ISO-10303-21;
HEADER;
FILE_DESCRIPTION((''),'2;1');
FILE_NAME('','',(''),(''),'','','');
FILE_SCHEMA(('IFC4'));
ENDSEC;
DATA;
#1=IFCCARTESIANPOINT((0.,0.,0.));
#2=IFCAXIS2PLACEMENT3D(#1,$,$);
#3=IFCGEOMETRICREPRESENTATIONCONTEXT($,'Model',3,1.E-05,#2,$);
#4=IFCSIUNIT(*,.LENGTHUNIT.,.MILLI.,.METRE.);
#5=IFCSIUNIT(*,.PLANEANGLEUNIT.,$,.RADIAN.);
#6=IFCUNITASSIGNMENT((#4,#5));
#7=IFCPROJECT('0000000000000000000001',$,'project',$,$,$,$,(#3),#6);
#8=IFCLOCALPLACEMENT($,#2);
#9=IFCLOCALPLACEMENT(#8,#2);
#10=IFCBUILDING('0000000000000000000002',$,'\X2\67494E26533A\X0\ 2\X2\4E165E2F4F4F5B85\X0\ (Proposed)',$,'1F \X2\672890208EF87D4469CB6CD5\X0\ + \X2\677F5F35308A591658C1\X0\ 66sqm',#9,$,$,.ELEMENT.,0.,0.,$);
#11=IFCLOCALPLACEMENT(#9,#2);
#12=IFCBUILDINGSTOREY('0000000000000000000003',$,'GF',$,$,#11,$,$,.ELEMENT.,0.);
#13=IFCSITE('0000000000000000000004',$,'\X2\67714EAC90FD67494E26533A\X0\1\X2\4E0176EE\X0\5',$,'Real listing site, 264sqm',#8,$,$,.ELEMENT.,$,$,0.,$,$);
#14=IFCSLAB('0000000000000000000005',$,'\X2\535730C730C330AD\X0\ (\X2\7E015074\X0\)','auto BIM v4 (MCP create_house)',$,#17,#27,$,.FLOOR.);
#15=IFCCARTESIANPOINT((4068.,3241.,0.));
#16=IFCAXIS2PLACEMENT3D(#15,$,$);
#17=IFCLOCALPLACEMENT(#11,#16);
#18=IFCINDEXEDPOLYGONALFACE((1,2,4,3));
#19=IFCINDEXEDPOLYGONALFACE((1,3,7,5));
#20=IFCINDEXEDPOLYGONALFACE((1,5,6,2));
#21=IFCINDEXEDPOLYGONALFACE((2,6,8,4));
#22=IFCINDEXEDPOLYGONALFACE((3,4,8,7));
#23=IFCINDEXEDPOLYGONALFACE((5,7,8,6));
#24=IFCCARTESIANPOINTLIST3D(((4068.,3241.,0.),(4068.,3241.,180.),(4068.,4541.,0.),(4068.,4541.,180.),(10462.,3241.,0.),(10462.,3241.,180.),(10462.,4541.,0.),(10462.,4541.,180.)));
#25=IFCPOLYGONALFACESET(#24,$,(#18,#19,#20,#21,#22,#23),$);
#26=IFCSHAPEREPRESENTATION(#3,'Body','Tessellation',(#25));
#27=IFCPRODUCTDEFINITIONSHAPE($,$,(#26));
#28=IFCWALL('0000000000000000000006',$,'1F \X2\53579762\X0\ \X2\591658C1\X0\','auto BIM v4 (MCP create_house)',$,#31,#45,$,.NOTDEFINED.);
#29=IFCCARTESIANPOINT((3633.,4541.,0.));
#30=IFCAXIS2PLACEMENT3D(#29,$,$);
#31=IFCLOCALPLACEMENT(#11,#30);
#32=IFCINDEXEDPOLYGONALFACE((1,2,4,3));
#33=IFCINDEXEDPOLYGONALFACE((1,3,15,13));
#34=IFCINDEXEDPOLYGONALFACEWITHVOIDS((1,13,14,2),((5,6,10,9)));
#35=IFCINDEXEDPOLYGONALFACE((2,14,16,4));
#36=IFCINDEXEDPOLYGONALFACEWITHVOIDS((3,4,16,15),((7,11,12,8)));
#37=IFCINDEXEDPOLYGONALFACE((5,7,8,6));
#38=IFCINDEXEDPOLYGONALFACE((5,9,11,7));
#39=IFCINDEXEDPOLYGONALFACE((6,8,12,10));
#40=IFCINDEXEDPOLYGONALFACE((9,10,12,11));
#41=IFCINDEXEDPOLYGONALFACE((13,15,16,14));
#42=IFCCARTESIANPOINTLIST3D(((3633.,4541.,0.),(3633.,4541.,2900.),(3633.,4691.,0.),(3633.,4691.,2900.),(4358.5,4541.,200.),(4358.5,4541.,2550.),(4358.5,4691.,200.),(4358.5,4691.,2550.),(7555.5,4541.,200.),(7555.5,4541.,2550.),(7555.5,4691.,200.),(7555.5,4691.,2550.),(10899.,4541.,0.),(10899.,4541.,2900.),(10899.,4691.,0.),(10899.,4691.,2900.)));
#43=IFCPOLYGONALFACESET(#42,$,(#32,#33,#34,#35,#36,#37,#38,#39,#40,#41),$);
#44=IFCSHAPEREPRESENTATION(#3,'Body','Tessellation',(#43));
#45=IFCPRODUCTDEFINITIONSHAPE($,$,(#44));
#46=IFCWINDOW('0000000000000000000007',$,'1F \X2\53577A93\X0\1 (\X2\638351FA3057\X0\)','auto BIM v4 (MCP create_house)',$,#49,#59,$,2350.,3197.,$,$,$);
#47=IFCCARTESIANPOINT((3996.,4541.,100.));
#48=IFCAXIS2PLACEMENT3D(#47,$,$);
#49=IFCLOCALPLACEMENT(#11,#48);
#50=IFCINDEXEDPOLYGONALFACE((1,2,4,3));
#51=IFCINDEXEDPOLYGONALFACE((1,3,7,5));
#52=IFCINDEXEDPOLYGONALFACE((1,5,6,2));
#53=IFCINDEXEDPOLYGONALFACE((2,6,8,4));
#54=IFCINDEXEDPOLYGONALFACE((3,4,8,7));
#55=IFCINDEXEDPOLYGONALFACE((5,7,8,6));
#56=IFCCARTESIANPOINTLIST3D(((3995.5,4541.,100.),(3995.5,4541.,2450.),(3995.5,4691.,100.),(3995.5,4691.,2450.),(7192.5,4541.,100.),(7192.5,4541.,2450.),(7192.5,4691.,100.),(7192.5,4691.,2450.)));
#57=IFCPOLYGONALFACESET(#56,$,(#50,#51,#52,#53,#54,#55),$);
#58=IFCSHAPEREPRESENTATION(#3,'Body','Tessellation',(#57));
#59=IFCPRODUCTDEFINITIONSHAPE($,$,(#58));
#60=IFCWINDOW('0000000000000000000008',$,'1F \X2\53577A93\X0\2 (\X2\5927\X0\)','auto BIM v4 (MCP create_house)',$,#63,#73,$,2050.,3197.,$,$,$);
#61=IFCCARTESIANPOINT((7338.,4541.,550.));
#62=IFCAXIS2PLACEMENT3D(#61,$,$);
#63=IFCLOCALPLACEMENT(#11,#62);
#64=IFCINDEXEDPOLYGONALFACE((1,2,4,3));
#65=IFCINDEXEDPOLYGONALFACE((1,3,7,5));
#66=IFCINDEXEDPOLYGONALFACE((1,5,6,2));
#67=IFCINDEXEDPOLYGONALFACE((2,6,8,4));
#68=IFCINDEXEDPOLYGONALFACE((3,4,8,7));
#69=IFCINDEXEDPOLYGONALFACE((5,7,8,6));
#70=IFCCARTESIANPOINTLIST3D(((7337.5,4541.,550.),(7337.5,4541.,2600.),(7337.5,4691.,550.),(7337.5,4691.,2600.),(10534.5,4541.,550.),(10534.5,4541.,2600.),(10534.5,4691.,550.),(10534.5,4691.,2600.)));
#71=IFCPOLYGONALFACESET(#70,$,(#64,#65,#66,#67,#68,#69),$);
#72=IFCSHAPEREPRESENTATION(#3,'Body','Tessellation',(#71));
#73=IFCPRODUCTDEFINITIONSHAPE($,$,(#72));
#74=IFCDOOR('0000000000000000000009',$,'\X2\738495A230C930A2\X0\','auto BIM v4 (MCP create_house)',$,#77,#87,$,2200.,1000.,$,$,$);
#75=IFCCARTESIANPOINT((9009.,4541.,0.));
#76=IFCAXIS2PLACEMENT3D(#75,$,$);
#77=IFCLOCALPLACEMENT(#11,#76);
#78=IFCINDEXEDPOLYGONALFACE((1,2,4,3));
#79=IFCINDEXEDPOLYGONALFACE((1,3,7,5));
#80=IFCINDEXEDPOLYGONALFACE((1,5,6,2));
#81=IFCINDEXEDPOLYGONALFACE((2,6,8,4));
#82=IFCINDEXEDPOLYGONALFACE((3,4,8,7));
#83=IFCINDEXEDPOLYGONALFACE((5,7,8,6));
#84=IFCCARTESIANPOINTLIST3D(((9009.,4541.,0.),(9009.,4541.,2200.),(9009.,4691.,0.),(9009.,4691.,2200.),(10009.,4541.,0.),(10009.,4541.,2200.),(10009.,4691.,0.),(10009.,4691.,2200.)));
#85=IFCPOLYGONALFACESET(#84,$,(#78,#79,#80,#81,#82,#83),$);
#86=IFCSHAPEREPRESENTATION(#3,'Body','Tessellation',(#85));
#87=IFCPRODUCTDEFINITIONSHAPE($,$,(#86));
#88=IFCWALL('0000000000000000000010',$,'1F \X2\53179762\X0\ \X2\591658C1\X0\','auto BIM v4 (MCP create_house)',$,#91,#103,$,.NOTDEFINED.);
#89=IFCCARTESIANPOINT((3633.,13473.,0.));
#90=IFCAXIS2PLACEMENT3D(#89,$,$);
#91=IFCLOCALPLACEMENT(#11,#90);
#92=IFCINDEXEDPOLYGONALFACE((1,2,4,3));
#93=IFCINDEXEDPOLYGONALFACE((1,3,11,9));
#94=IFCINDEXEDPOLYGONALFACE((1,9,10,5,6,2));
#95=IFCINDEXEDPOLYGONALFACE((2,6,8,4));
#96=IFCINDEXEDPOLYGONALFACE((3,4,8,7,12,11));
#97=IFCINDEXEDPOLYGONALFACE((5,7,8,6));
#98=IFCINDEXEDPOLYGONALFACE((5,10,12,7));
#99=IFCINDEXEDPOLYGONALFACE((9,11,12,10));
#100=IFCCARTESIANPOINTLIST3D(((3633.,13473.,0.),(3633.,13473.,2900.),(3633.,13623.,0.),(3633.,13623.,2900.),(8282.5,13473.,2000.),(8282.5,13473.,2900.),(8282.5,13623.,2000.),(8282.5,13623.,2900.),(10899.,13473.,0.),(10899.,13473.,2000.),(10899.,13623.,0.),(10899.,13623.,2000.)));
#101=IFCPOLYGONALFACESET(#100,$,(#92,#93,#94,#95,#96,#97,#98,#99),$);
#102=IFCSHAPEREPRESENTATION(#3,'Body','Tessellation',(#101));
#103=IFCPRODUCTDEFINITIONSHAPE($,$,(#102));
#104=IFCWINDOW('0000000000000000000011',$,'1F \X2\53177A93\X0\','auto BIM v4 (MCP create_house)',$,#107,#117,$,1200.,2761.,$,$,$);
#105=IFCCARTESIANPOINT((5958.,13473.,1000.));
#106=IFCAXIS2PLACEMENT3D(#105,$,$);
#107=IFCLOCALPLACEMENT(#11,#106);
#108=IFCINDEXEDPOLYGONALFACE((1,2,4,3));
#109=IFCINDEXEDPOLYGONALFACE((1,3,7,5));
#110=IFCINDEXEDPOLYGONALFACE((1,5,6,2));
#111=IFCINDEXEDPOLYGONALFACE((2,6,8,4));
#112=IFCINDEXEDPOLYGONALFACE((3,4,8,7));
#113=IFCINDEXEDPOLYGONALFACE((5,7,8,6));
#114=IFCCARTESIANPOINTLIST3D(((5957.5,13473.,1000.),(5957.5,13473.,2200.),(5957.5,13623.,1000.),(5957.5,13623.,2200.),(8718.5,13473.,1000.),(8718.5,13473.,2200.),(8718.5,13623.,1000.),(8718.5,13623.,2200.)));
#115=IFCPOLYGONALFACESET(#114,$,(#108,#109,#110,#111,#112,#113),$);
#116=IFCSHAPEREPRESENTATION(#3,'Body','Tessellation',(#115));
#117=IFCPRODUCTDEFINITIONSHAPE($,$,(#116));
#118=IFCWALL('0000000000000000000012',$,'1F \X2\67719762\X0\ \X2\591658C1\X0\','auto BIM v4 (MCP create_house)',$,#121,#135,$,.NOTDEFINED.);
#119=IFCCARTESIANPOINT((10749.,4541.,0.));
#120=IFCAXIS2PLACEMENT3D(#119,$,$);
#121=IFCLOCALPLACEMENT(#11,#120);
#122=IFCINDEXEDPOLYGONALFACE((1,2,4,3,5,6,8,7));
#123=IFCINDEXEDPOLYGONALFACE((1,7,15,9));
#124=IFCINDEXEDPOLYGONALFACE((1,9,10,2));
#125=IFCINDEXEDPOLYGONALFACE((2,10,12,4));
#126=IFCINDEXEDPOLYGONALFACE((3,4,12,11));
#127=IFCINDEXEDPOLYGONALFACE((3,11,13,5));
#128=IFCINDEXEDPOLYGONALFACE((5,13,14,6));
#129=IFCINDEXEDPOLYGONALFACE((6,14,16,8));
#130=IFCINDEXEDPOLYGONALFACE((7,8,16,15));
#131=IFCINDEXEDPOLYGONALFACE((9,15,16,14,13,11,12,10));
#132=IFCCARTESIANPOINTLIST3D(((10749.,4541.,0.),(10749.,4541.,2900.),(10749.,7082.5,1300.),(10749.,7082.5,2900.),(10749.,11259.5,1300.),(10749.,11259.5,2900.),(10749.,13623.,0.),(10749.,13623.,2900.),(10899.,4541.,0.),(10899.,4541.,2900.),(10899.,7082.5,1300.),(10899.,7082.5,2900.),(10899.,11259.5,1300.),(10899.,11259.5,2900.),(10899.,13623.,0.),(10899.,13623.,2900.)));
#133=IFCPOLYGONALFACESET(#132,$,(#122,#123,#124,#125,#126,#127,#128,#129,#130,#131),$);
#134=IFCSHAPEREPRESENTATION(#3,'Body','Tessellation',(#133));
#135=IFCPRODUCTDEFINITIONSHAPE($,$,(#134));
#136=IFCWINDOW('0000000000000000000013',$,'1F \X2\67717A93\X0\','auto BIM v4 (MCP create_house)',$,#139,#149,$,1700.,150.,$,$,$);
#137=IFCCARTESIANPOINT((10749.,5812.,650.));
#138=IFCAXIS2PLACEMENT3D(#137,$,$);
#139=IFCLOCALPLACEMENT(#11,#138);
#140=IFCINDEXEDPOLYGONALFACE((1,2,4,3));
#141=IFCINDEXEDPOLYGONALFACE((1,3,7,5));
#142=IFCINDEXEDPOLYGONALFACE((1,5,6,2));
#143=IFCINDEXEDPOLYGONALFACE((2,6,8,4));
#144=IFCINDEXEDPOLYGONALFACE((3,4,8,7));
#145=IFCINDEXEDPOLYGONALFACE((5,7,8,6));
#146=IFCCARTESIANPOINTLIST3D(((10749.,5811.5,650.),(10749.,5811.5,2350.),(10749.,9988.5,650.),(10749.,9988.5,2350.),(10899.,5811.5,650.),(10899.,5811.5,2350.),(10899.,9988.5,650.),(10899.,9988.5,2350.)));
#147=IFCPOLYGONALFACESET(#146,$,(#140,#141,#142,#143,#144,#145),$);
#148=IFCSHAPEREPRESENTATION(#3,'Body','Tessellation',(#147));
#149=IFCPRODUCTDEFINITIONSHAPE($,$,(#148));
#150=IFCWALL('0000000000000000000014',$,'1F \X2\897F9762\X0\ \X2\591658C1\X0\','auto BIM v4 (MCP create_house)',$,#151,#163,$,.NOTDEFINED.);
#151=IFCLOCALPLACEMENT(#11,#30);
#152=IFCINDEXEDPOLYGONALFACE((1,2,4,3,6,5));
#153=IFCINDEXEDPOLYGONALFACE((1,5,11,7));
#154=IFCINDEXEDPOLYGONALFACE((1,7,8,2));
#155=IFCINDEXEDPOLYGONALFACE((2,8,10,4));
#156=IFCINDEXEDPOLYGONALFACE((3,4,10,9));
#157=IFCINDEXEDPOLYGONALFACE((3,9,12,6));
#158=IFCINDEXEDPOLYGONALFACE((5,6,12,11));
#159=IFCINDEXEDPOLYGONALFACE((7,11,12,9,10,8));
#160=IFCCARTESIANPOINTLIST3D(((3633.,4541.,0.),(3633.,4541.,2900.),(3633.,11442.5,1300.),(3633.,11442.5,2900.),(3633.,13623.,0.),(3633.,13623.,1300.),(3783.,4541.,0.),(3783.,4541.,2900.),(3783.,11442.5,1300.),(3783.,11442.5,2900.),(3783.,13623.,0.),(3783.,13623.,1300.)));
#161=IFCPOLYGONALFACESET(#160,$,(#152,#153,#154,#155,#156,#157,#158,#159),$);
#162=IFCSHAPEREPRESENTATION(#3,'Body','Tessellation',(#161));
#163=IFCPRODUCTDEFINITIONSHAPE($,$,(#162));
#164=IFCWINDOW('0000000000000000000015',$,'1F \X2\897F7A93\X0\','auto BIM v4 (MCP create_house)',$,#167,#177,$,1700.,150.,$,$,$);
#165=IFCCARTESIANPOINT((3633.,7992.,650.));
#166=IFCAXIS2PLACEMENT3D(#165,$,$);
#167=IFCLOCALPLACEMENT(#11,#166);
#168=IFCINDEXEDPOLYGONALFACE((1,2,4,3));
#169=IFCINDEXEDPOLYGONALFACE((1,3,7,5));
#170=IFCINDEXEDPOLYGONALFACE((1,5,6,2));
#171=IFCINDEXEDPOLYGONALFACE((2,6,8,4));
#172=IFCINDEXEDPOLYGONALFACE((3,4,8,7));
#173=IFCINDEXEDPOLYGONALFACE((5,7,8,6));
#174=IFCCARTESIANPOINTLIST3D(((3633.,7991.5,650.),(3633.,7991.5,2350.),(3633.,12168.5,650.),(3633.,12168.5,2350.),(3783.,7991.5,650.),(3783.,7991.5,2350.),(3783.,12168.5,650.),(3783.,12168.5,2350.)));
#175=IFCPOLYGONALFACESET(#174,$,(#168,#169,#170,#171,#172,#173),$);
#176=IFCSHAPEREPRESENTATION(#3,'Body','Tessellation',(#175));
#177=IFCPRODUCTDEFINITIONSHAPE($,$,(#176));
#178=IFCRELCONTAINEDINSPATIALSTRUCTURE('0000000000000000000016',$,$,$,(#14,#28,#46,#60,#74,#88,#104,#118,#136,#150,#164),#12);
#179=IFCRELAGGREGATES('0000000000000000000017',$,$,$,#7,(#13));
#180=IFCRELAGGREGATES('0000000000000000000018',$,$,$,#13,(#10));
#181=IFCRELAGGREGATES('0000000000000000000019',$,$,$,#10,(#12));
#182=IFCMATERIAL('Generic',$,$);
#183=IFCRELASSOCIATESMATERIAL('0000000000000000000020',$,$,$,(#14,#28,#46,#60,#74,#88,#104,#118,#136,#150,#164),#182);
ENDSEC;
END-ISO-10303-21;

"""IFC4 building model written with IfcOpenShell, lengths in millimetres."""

from ifc_helpers import new_model, si_unit, frame, frame_2d, origin, place, context, project, spatial, rectangle, extrude, material, element, fill, save


model = new_model("IFC4")

# Units and contexts
model_context = context("Model", 3, precision=1e-05, world=origin())
ifc_project = project(units=[si_unit("LENGTHUNIT", "METRE", prefix="MILLI"), si_unit("PLANEANGLEUNIT", "RADIAN")], contexts=[model_context])

# Site, building, storey
site_placement = place(None, origin())
site = spatial("IfcSite", under=ifc_project, at=site_placement, Name="東京都杉並区1丁目5", ObjectType="Real listing site, 264sqm", CompositionType="ELEMENT", RefElevation=0.0)
building_placement = place(site_placement, origin())
building = spatial("IfcBuilding", under=site, at=building_placement, Name="杉並区 2世帯住宅 (Proposed)", ObjectType="1F 木造軸組構法 + 板張り外壁 66sqm", CompositionType="ELEMENT", ElevationOfRefHeight=0.0, ElevationOfTerrain=0.0)
storey_placement = place(building_placement, origin())
storey = spatial("IfcBuildingStorey", under=building, at=storey_placement, Name="GF", CompositionType="ELEMENT", Elevation=0.0)

# Slab
ifc_material = material(Name="Generic")
slab_1_placement = place(storey_placement, frame((4068.0, 3241.0, 0.0)))
element("IfcSlab", 1, at=slab_1_placement, inside=storey, material=ifc_material, Name="南デッキ (縁側)", Description="auto BIM v4 (MCP create_house)", PredefinedType="FLOOR", context=model_context, shape_type="SweptSolid", body=[
    extrude(rectangle(XDim=6394.0, YDim=1300.0, at=frame_2d((3197.0, 650.0))), frame((4068.0, 3241.0, 0.0)), (0.0, 0.0, 1.0), 180.0),
])

# Wall, openings, windows, door
wall_1_placement = place(storey_placement, frame((3633.0, 4541.0, 0.0)))
wall_1 = element("IfcWall", 2, at=wall_1_placement, inside=storey, material=ifc_material, Name="1F 南面 外壁", Description="auto BIM v4 (MCP create_house)", PredefinedType="NOTDEFINED", context=model_context, shape_type="SweptSolid", body=[
    extrude(rectangle(XDim=7266.0, YDim=150.0, at=frame_2d((3633.0, 75.0))), frame((3633.0, 4541.0, 0.0)), (0.0, 0.0, 1.0), 2900.0),
])
opening_1_placement = place(storey_placement, frame((3996.0, 4541.0, 100.0)))
opening_1 = element("IfcOpeningElement", 3, at=opening_1_placement, cuts=wall_1, PredefinedType="NOTDEFINED", context=model_context, shape_type="SweptSolid", body=[
    extrude(rectangle(XDim=3197.0, YDim=150.0, at=frame_2d((1598.0, 75.0))), frame((3996.0, 4541.0, 100.0)), (0.0, 0.0, 1.0), 2350.0),
])
opening_2_placement = place(storey_placement, frame((7338.0, 4541.0, 550.0)))
opening_2 = element("IfcOpeningElement", 4, at=opening_2_placement, cuts=wall_1, PredefinedType="NOTDEFINED", context=model_context, shape_type="SweptSolid", body=[
    extrude(rectangle(XDim=3197.0, YDim=150.0, at=frame_2d((1598.0, 75.0))), frame((7338.0, 4541.0, 550.0)), (0.0, 0.0, 1.0), 2050.0),
])
opening_3_placement = place(storey_placement, frame((9009.0, 4541.0, 0.0)))
opening_3 = element("IfcOpeningElement", 5, at=opening_3_placement, cuts=wall_1, PredefinedType="NOTDEFINED", context=model_context, shape_type="SweptSolid", body=[
    extrude(rectangle(XDim=1000.0, YDim=150.0, at=frame_2d((500.0, 75.0))), frame((9009.0, 4541.0, 0.0)), (0.0, 0.0, 1.0), 2200.0),
])
window_1_placement = place(storey_placement, frame((3996.0, 4541.0, 100.0)))
window_1 = element("IfcWindow", 6, at=window_1_placement, inside=storey, material=ifc_material, Name="1F 南窓1 (掃出し)", Description="auto BIM v4 (MCP create_house)", OverallHeight=2350.0, OverallWidth=3197.0, context=model_context, shape_type="SweptSolid", body=[
    extrude(rectangle(XDim=3197.0, YDim=150.0, at=frame_2d((1598.0, 75.0))), frame((3996.0, 4541.0, 100.0)), (0.0, 0.0, 1.0), 2350.0),
])
fill(opening_1, window_1)
window_2_placement = place(storey_placement, frame((7338.0, 4541.0, 550.0)))
window_2 = element("IfcWindow", 7, at=window_2_placement, inside=storey, material=ifc_material, Name="1F 南窓2 (大)", Description="auto BIM v4 (MCP create_house)", OverallHeight=2050.0, OverallWidth=3197.0, context=model_context, shape_type="SweptSolid", body=[
    extrude(rectangle(XDim=3197.0, YDim=150.0, at=frame_2d((1598.0, 75.0))), frame((7338.0, 4541.0, 550.0)), (0.0, 0.0, 1.0), 2050.0),
])
fill(opening_2, window_2)
door_placement = place(storey_placement, frame((9009.0, 4541.0, 0.0)))
door = element("IfcDoor", 8, at=door_placement, inside=storey, material=ifc_material, Name="玄関ドア", Description="auto BIM v4 (MCP create_house)", OverallHeight=2200.0, OverallWidth=1000.0, context=model_context, shape_type="SweptSolid", body=[
    extrude(rectangle(XDim=1000.0, YDim=150.0, at=frame_2d((500.0, 75.0))), frame((9009.0, 4541.0, 0.0)), (0.0, 0.0, 1.0), 2200.0),
])
fill(opening_3, door)

# Walls, openings, windows
wall_2_placement = place(storey_placement, frame((3633.0, 13473.0, 0.0)))
wall_2 = element("IfcWall", 9, at=wall_2_placement, inside=storey, material=ifc_material, Name="1F 北面 外壁", Description="auto BIM v4 (MCP create_house)", PredefinedType="NOTDEFINED", context=model_context, shape_type="SweptSolid", body=[
    extrude(rectangle(XDim=7266.0, YDim=150.0, at=frame_2d((3633.0, 75.0))), frame((3633.0, 13473.0, 0.0)), (0.0, 0.0, 1.0), 2900.0),
])
opening_4_placement = place(storey_placement, frame((5958.0, 13473.0, 1000.0)))
opening_4 = element("IfcOpeningElement", 10, at=opening_4_placement, cuts=wall_2, PredefinedType="NOTDEFINED", context=model_context, shape_type="SweptSolid", body=[
    extrude(rectangle(XDim=2761.0, YDim=150.0, at=frame_2d((1380.0, 75.0))), frame((5958.0, 13473.0, 1000.0)), (0.0, 0.0, 1.0), 1200.0),
])
window_3_placement = place(storey_placement, frame((5958.0, 13473.0, 1000.0)))
window_3 = element("IfcWindow", 11, at=window_3_placement, inside=storey, material=ifc_material, Name="1F 北窓", Description="auto BIM v4 (MCP create_house)", OverallHeight=1200.0, OverallWidth=2761.0, context=model_context, shape_type="SweptSolid", body=[
    extrude(rectangle(XDim=2761.0, YDim=150.0, at=frame_2d((1380.0, 75.0))), frame((5958.0, 13473.0, 1000.0)), (0.0, 0.0, 1.0), 1200.0),
])
fill(opening_4, window_3)
wall_3_placement = place(storey_placement, frame((10749.0, 4541.0, 0.0)))
wall_3 = element("IfcWall", 12, at=wall_3_placement, inside=storey, material=ifc_material, Name="1F 東面 外壁", Description="auto BIM v4 (MCP create_house)", PredefinedType="NOTDEFINED", context=model_context, shape_type="SweptSolid", body=[
    extrude(rectangle(XDim=150.0, YDim=9082.0, at=frame_2d((75.0, 4541.0))), frame((10749.0, 4541.0, 0.0)), (0.0, 0.0, 1.0), 2900.0),
])
opening_5_placement = place(storey_placement, frame((10749.0, 5812.0, 650.0)))
opening_5 = element("IfcOpeningElement", 13, at=opening_5_placement, cuts=wall_3, PredefinedType="NOTDEFINED", context=model_context, shape_type="SweptSolid", body=[
    extrude(rectangle(XDim=150.0, YDim=4177.0, at=frame_2d((75.0, 2088.0))), frame((10749.0, 5812.0, 650.0)), (0.0, 0.0, 1.0), 1700.0),
])
window_4_placement = place(storey_placement, frame((10749.0, 5812.0, 650.0)))
window_4 = element("IfcWindow", 14, at=window_4_placement, inside=storey, material=ifc_material, Name="1F 東窓", Description="auto BIM v4 (MCP create_house)", OverallHeight=1700.0, OverallWidth=150.0, context=model_context, shape_type="SweptSolid", body=[
    extrude(rectangle(XDim=150.0, YDim=4177.0, at=frame_2d((75.0, 2088.0))), frame((10749.0, 5812.0, 650.0)), (0.0, 0.0, 1.0), 1700.0),
])
fill(opening_5, window_4)
wall_4_placement = place(storey_placement, frame((3633.0, 4541.0, 0.0)))
wall_4 = element("IfcWall", 15, at=wall_4_placement, inside=storey, material=ifc_material, Name="1F 西面 外壁", Description="auto BIM v4 (MCP create_house)", PredefinedType="NOTDEFINED", context=model_context, shape_type="SweptSolid", body=[
    extrude(rectangle(XDim=150.0, YDim=9082.0, at=frame_2d((75.0, 4541.0))), frame((3633.0, 4541.0, 0.0)), (0.0, 0.0, 1.0), 2900.0),
])
opening_6_placement = place(storey_placement, frame((3633.0, 7992.0, 650.0)))
opening_6 = element("IfcOpeningElement", 16, at=opening_6_placement, cuts=wall_4, PredefinedType="NOTDEFINED", context=model_context, shape_type="SweptSolid", body=[
    extrude(rectangle(XDim=150.0, YDim=4177.0, at=frame_2d((75.0, 2088.0))), frame((3633.0, 7992.0, 650.0)), (0.0, 0.0, 1.0), 1700.0),
])
window_5_placement = place(storey_placement, frame((3633.0, 7992.0, 650.0)))
window_5 = element("IfcWindow", 17, at=window_5_placement, inside=storey, material=ifc_material, Name="1F 西窓", Description="auto BIM v4 (MCP create_house)", OverallHeight=1700.0, OverallWidth=150.0, context=model_context, shape_type="SweptSolid", body=[
    extrude(rectangle(XDim=150.0, YDim=4177.0, at=frame_2d((75.0, 2088.0))), frame((3633.0, 7992.0, 650.0)), (0.0, 0.0, 1.0), 1700.0),
])
fill(opening_6, window_5)

save(model, "model.ifc")
